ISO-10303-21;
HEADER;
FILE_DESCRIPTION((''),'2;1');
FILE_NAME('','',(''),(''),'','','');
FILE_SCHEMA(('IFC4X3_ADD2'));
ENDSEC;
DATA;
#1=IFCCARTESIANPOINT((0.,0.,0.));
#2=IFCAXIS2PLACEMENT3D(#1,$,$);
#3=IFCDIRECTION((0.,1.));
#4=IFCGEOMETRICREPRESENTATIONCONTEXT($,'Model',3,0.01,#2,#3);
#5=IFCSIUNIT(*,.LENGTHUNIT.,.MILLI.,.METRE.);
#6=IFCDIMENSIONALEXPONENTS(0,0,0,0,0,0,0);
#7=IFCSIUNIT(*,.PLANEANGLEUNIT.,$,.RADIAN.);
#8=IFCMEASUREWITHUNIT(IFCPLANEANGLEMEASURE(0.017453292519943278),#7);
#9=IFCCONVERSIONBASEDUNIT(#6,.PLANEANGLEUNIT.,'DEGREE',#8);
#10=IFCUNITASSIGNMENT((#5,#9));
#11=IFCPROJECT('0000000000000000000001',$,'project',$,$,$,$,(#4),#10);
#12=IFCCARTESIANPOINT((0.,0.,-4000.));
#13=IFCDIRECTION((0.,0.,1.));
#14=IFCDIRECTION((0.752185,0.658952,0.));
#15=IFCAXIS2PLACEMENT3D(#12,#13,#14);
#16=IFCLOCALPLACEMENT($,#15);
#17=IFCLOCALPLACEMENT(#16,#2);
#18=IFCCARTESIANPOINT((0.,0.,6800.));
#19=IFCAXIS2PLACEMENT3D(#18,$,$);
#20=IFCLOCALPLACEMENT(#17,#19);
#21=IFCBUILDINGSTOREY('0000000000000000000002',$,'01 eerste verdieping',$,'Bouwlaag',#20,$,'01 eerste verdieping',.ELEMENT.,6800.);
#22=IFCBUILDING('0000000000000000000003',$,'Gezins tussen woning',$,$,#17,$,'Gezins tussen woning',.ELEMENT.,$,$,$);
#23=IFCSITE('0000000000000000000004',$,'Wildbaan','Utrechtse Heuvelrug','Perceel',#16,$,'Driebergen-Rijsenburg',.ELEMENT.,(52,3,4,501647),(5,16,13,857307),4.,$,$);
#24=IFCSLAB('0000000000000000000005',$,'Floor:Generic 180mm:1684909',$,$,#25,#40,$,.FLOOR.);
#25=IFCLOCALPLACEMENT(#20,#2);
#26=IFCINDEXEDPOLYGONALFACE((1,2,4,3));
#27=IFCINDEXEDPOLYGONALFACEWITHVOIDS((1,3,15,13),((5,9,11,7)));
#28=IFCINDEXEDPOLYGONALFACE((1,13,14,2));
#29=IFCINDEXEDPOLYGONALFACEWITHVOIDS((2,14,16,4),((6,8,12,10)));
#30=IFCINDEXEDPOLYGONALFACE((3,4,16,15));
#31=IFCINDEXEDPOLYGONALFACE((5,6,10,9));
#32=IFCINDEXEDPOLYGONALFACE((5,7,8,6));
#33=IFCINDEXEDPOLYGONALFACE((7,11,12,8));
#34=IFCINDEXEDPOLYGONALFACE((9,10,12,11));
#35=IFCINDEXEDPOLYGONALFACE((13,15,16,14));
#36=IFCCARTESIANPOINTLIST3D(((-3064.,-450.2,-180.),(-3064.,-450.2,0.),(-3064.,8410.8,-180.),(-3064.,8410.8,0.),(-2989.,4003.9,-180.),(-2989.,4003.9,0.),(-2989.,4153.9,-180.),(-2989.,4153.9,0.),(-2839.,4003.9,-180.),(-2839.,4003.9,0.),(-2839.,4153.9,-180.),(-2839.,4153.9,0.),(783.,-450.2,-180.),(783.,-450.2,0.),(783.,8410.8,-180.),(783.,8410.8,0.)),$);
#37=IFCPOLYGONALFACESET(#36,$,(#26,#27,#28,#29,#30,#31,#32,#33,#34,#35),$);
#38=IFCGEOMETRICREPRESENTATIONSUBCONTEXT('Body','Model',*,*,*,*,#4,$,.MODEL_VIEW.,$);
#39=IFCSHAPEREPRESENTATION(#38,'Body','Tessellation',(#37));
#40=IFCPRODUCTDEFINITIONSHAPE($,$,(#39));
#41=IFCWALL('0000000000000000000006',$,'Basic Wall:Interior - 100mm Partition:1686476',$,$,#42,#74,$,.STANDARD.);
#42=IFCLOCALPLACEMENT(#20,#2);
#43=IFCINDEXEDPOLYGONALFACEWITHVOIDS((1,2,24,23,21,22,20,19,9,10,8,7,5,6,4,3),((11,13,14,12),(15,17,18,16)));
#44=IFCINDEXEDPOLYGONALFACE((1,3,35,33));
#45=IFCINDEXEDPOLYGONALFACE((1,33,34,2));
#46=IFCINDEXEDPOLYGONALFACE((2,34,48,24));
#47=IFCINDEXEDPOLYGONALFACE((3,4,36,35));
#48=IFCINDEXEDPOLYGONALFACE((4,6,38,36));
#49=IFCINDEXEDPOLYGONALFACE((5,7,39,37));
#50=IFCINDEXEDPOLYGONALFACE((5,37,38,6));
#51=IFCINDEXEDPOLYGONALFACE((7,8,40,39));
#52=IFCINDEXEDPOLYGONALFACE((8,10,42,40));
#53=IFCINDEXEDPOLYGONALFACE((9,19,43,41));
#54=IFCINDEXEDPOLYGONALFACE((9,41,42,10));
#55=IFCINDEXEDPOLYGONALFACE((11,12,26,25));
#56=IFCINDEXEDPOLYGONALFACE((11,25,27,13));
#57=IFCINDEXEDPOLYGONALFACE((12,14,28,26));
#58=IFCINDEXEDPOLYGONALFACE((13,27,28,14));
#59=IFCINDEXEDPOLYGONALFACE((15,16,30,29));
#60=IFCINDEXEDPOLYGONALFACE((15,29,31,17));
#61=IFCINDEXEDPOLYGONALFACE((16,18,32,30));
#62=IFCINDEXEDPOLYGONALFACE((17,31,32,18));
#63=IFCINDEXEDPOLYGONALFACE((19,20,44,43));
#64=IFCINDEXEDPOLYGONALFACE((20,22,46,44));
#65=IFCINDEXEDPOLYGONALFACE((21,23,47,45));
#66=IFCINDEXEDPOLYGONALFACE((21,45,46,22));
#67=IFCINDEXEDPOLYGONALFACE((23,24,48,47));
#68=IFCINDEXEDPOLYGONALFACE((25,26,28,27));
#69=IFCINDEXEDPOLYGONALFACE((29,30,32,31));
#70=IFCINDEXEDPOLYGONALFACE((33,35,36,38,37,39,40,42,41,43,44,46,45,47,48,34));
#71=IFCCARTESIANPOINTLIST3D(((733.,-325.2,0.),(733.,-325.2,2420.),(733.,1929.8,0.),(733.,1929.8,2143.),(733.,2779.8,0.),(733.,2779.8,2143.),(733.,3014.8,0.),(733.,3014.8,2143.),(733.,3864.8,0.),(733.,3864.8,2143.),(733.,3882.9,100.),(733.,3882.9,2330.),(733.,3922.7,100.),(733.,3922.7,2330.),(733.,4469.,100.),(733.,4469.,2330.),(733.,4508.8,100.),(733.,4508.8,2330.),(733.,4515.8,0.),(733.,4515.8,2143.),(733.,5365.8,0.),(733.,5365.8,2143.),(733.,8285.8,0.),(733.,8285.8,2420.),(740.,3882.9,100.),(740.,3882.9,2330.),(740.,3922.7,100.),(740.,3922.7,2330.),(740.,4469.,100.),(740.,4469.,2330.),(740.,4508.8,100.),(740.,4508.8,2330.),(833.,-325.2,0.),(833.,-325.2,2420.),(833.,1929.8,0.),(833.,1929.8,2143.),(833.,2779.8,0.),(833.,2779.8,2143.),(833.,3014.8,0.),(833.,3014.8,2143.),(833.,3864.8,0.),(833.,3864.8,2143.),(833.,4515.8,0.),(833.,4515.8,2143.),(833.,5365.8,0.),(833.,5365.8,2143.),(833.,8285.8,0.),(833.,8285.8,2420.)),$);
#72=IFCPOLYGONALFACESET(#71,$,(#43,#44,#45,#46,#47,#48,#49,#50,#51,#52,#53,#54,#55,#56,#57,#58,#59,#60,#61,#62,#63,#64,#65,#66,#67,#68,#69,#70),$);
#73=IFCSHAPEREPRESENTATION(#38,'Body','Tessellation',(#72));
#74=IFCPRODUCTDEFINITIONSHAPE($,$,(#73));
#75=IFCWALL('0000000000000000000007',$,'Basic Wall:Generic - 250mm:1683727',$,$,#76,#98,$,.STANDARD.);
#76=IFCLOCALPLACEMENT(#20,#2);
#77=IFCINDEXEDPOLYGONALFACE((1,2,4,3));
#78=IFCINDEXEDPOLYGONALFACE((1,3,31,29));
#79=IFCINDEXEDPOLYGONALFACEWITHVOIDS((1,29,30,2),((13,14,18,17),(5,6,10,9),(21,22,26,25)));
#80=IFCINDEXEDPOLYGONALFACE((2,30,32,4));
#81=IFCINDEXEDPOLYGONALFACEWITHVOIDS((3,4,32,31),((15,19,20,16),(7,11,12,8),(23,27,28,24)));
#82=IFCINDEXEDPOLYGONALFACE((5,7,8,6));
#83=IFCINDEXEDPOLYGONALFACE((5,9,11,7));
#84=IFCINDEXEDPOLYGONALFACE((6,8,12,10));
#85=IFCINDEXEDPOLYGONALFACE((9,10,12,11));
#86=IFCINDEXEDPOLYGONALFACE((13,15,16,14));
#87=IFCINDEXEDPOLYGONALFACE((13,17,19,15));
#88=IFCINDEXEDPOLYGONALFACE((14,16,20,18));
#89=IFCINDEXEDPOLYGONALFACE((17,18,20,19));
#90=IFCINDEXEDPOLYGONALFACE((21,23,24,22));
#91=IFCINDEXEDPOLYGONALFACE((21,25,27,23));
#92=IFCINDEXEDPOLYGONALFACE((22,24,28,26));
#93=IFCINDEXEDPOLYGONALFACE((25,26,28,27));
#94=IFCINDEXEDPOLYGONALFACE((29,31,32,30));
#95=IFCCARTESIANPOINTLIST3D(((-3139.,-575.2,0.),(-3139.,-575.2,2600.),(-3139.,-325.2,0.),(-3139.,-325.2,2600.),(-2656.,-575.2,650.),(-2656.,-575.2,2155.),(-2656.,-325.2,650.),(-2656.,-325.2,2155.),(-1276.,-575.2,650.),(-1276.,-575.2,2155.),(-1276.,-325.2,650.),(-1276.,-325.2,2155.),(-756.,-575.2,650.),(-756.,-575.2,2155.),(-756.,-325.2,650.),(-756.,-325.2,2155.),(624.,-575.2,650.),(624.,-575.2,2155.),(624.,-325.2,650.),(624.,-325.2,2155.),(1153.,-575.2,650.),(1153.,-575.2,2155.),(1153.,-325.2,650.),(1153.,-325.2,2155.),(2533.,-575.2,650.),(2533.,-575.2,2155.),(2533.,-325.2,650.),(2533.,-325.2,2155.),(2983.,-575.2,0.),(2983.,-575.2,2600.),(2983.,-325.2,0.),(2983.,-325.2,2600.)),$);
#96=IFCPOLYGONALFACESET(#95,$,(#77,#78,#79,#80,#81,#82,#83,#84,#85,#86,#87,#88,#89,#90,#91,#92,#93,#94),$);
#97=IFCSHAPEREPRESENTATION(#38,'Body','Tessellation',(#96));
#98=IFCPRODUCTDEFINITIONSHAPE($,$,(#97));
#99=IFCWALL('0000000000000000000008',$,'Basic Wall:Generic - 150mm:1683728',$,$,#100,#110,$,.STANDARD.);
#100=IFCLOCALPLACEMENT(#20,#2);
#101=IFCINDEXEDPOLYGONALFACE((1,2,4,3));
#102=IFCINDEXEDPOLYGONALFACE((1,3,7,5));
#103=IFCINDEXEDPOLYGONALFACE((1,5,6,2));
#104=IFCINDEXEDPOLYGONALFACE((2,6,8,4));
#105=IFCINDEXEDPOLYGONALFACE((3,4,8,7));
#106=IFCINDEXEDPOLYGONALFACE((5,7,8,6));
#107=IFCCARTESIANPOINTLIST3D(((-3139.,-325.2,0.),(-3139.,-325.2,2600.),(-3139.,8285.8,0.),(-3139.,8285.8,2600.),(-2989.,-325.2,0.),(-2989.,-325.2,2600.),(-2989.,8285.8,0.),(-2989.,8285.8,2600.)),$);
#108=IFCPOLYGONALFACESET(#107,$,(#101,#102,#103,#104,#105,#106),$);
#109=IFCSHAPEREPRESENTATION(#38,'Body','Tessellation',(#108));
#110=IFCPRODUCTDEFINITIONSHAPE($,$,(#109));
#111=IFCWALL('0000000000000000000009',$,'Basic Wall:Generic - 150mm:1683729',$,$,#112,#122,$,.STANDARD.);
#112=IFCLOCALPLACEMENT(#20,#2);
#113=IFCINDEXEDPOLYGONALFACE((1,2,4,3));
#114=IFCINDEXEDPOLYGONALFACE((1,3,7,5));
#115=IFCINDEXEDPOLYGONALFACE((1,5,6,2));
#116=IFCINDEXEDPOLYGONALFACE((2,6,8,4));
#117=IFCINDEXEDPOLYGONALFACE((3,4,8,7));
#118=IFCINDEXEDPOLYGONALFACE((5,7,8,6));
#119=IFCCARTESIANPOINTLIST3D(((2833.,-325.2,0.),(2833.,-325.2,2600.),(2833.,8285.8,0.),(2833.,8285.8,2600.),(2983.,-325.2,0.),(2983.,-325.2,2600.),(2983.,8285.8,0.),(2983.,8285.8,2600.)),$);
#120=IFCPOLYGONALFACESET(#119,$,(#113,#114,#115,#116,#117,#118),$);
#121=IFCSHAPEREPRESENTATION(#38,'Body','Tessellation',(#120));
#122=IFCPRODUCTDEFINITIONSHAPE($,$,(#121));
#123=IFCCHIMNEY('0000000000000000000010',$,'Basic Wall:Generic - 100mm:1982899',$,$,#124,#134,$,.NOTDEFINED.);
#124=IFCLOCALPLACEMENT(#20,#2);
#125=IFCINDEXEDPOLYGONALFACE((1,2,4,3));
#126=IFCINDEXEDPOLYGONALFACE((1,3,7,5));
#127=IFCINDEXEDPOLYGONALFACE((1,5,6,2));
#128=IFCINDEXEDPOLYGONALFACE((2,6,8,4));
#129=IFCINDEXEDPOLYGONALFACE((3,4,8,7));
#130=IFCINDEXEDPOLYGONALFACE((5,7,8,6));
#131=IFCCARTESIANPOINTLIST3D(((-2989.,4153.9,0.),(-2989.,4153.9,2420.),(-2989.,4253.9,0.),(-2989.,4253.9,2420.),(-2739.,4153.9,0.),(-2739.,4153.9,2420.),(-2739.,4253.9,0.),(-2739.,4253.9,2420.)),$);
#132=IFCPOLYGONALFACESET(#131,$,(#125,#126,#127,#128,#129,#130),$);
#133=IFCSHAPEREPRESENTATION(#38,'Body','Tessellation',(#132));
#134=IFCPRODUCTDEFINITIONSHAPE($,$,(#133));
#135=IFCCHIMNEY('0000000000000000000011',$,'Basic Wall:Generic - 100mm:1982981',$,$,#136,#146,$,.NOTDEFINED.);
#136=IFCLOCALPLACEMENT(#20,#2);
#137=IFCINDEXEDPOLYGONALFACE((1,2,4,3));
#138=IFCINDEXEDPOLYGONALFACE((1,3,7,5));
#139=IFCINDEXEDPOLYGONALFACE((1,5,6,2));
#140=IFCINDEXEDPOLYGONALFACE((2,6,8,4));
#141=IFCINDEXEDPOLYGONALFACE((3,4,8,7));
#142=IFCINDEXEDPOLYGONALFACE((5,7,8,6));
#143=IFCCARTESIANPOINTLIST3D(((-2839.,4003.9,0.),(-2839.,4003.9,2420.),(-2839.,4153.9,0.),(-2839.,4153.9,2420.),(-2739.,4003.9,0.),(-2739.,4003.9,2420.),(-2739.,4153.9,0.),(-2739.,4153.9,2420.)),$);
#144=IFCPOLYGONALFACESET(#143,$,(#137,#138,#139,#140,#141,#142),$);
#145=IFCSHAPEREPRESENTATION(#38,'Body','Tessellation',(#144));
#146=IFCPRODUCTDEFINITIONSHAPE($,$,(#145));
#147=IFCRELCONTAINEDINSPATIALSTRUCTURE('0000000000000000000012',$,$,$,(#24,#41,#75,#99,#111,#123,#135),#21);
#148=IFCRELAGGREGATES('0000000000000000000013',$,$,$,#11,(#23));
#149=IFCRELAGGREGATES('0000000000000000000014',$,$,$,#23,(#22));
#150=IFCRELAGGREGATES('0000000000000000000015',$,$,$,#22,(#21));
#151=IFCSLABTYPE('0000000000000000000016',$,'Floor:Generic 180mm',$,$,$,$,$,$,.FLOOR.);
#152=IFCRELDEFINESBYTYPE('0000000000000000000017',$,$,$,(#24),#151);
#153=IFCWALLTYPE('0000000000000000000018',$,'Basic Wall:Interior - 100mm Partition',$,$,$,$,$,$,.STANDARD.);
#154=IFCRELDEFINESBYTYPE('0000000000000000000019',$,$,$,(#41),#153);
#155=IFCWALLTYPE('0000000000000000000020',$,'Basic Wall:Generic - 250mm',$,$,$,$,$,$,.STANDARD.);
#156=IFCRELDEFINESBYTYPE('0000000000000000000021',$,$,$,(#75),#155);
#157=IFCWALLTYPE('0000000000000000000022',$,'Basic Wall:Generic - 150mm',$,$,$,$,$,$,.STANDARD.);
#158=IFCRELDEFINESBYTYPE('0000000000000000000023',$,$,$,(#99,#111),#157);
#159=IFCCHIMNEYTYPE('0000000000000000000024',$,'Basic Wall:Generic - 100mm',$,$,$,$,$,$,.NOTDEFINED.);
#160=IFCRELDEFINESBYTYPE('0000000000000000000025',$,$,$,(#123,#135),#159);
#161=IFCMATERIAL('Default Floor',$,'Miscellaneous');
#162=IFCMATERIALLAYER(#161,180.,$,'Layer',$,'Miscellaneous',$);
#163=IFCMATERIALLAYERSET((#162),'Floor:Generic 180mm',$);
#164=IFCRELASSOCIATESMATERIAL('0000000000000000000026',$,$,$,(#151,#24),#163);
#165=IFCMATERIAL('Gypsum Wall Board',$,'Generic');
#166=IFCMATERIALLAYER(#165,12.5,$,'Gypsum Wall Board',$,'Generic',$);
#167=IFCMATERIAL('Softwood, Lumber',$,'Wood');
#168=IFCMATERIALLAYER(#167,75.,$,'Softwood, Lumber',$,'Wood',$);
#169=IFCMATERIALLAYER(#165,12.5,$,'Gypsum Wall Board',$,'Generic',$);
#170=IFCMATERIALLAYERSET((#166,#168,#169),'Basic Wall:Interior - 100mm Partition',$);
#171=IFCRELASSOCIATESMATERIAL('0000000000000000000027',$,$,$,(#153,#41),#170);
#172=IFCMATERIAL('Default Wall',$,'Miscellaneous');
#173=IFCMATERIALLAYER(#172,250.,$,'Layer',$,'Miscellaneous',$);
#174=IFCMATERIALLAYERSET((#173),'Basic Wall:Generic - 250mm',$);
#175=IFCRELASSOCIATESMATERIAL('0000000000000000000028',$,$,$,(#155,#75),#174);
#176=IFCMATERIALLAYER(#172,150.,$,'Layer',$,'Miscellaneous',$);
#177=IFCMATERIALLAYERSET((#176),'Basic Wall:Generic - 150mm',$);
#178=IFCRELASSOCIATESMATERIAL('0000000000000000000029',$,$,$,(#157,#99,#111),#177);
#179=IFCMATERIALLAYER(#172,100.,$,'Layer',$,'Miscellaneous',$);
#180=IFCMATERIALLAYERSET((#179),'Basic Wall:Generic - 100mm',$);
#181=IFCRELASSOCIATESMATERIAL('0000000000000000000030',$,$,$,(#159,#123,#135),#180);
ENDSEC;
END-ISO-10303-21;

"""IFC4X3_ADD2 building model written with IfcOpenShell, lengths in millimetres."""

from ifc_helpers import new_model, entity, si_unit, converted_unit, direction, frame, frame_2d, origin, place, context, subcontext, project, spatial, rectangle, extrude, boolean, material, layer, layer_set, layer_usage, type_object, element, save


model = new_model("IFC4X3_ADD2")

# Units and contexts
model_context = context("Model", 3, precision=0.01, world=origin(), true_north=direction((0.0, 1.0)))
body_context = subcontext(model_context, "Body", "Model", "MODEL_VIEW")
ifc_project = project(units=[si_unit("LENGTHUNIT", "METRE", prefix="MILLI"), converted_unit("PLANEANGLEUNIT", "DEGREE", entity("IfcPlaneAngleMeasure", 0.017453292519943278), si_unit("PLANEANGLEUNIT", "RADIAN"), dimensions=[0, 0, 0, 0, 0, 0, 0])], contexts=[model_context])

# Site, building, storey
site_placement = place(None, frame((0.0, 0.0, -4000.0), z_axis=(0.0, 0.0, 1.0), x_axis=(0.752185, 0.658952, 0.0)))
site = spatial("IfcSite", under=ifc_project, at=site_placement, Name="Wildbaan", Description="Utrechtse Heuvelrug", ObjectType="Perceel", LongName="Driebergen-Rijsenburg", CompositionType="ELEMENT", RefLatitude=(52, 3, 4, 501647), RefLongitude=(5, 16, 13, 857307), RefElevation=4.0)
building_placement = place(site_placement, origin())
building = spatial("IfcBuilding", under=site, at=building_placement, Name="Gezins tussen woning", LongName="Gezins tussen woning", CompositionType="ELEMENT")
storey_placement = place(building_placement, frame((0.0, 0.0, 6800.0)))
storey = spatial("IfcBuildingStorey", under=building, at=storey_placement, Name="01 eerste verdieping", ObjectType="Bouwlaag", LongName="01 eerste verdieping", CompositionType="ELEMENT", Elevation=6800.0)

# Slab, opening
ifc_material_1 = material(Name="Default Floor", Category="Miscellaneous")
ifc_layer_1 = layer(ifc_material_1, 180.0, Name="Layer", Category="Miscellaneous")
ifc_layer_set_1 = layer_set([ifc_layer_1], Name="Floor:Generic 180mm")
ifc_layer_usage_1 = layer_usage(ifc_layer_set_1, "AXIS3", "POSITIVE", 0.0)
slab_type = type_object("IfcSlabType", Name="Floor:Generic 180mm", PredefinedType="FLOOR", material=ifc_layer_set_1)
slab_1_placement = place(storey_placement, origin())
slab_1 = element("IfcSlab", 1, at=slab_1_placement, inside=storey, type_object=slab_type, material=ifc_layer_usage_1, Name="Floor:Generic 180mm:1684909", PredefinedType="FLOOR", context=body_context, shape_type="CSG", body=[
    boolean("DIFFERENCE", extrude(rectangle(XDim=8861.0, YDim=3847.0, at=frame_2d((0.0, 0.0), x_axis=(1.0, 0.0))), frame((-1140.5, 3980.3, 0.0), z_axis=(0.0, 0.0, -1.0), x_axis=(0.0, 1.0, 0.0)), (0.0, 0.0, 1.0), 180.0), extrude(rectangle(XDim=150.0, YDim=150.0, at=frame_2d((0.0, 0.0), x_axis=(1.0, 0.0))), frame((-2914.0, 4078.9, -180.0), z_axis=(0.0, 0.0, 1.0), x_axis=(0.0, 1.0, 0.0)), (0.0, 0.0, 1.0), 180.0)),
])
opening_1_placement = place(slab_1_placement, origin())
element("IfcOpeningElement", 2, at=opening_1_placement, cuts=slab_1, PredefinedType="OPENING", context=body_context, shape_type="SweptSolid", body=[
    extrude(rectangle(XDim=150.0, YDim=150.0, at=frame_2d((-2914.0, 4078.9), x_axis=(0.0, -1.0))), origin(), (0.0, 0.0, -1.0), 180.0),
])

# Walls, openings
ifc_material_2 = material(Name="Gypsum Wall Board", Category="Generic")
ifc_layer_2 = layer(ifc_material_2, 12.5, Name="Gypsum Wall Board", Category="Generic")
ifc_material_3 = material(Name="Softwood, Lumber", Category="Wood")
ifc_layer_3 = layer(ifc_material_3, 75.0, Name="Softwood, Lumber", Category="Wood")
ifc_layer_4 = layer(ifc_material_2, 12.5, Name="Gypsum Wall Board", Category="Generic")
ifc_layer_set_2 = layer_set([ifc_layer_2, ifc_layer_3, ifc_layer_4], Name="Basic Wall:Interior - 100mm Partition")
wall_type_1 = type_object("IfcWallType", Name="Basic Wall:Interior - 100mm Partition", PredefinedType="STANDARD", material=ifc_layer_set_2)
wall_1_placement = place(storey_placement, frame((783.0, -325.2, 0.0), z_axis=(0.0, 0.0, 1.0), x_axis=(0.0, 1.0, 0.0)))
wall_1 = element("IfcWall", 3, at=wall_1_placement, inside=storey, type_object=wall_type_1, material=ifc_layer_set_2, Name="Basic Wall:Interior - 100mm Partition:1686476", PredefinedType="STANDARD", context=body_context, shape_type="SweptSolid", body=[
    extrude(rectangle(XDim=8611.0, YDim=100.0, at=frame_2d((4305.5, 0.0), x_axis=(1.0, 0.0))), origin(), (0.0, 0.0, 1.0), 2420.0),
])
opening_2_placement = place(wall_1_placement, frame((325.2, 783.0, 100.0)))
element("IfcOpeningElement", 4, at=opening_2_placement, cuts=wall_1, PredefinedType="OPENING", context=body_context, shape_type="SweptSolid", body=[
    extrude(rectangle(XDim=2230.0, YDim=39.8, at=frame_2d((0.0, 0.0), x_axis=(0.0, 1.0))), frame((4488.9, -740.0, 1115.0), z_axis=(0.0, 1.0, 0.0), x_axis=(1.0, 0.0, 0.0)), (0.0, 0.0, 1.0), 810.0),
])
opening_3_placement = place(wall_1_placement, frame((325.2, 783.0, 100.0)))
element("IfcOpeningElement", 5, at=opening_3_placement, cuts=wall_1, PredefinedType="OPENING", context=body_context, shape_type="SweptSolid", body=[
    extrude(rectangle(XDim=2230.0, YDim=39.8, at=frame_2d((0.0, 0.0), x_axis=(0.0, 1.0))), frame((3902.8, -740.0, 1115.0), z_axis=(0.0, 1.0, 0.0), x_axis=(1.0, 0.0, 0.0)), (0.0, 0.0, 1.0), 810.0),
])
opening_4_placement = place(wall_1_placement, frame((325.2, 783.0, -2.0), z_axis=(0.0, 0.0, 1.0), x_axis=(0.0, -1.0, 0.0)))
element("IfcOpeningElement", 6, at=opening_4_placement, cuts=wall_1, PredefinedType="OPENING", context=body_context, shape_type="SweptSolid", body=[
    extrude(rectangle(XDim=2145.0, YDim=850.0, at=frame_2d((0.0, 0.0), x_axis=(1.0, 0.0))), frame((833.0, 3439.8, 1072.5), z_axis=(-1.0, 0.0, 0.0), x_axis=(0.0, 0.0, -1.0)), (0.0, 0.0, 1.0), 100.0),
])
opening_5_placement = place(wall_1_placement, frame((325.2, 783.0, -2.0), z_axis=(0.0, 0.0, 1.0), x_axis=(0.0, -1.0, 0.0)))
element("IfcOpeningElement", 7, at=opening_5_placement, cuts=wall_1, PredefinedType="OPENING", context=body_context, shape_type="SweptSolid", body=[
    extrude(rectangle(XDim=2145.0, YDim=850.0, at=frame_2d((0.0, 0.0), x_axis=(0.0, 1.0))), frame((833.0, 4940.8, 1072.5), z_axis=(-1.0, 0.0, 0.0), x_axis=(0.0, 1.0, 0.0)), (0.0, 0.0, 1.0), 100.0),
])
opening_6_placement = place(wall_1_placement, frame((325.2, 783.0, -2.0), z_axis=(0.0, 0.0, 1.0), x_axis=(0.0, -1.0, 0.0)))
element("IfcOpeningElement", 8, at=opening_6_placement, cuts=wall_1, PredefinedType="OPENING", context=body_context, shape_type="SweptSolid", body=[
    extrude(rectangle(XDim=2145.0, YDim=850.0, at=frame_2d((0.0, 0.0), x_axis=(1.0, 0.0))), frame((833.0, 2354.8, 1072.5), z_axis=(-1.0, 0.0, 0.0), x_axis=(0.0, 0.0, -1.0)), (0.0, 0.0, 1.0), 100.0),
])
ifc_material_4 = material(Name="Default Wall", Category="Miscellaneous")
ifc_layer_5 = layer(ifc_material_4, 250.0, Name="Layer", Category="Miscellaneous")
ifc_layer_set_3 = layer_set([ifc_layer_5], Name="Basic Wall:Generic - 250mm")
wall_type_2 = type_object("IfcWallType", Name="Basic Wall:Generic - 250mm", PredefinedType="STANDARD", material=ifc_layer_set_3)
wall_2_placement = place(storey_placement, frame((-3139.0, -450.2, 0.0)))
wall_2 = element("IfcWall", 9, at=wall_2_placement, inside=storey, type_object=wall_type_2, material=ifc_layer_set_3, Name="Basic Wall:Generic - 250mm:1683727", PredefinedType="STANDARD", context=body_context, shape_type="SweptSolid", body=[
    extrude(rectangle(XDim=6122.0, YDim=250.0, at=frame_2d((3061.0, 0.0), x_axis=(-1.0, 0.0))), origin(), (0.0, 0.0, 1.0), 2600.0),
])
opening_7_placement = place(wall_2_placement, frame((3139.0, 450.2, 650.0)))
element("IfcOpeningElement", 10, at=opening_7_placement, cuts=wall_2, PredefinedType="OPENING", context=body_context, shape_type="SweptSolid", body=[
    extrude(rectangle(XDim=1505.0, YDim=1380.0, at=frame_2d((0.0, 0.0), x_axis=(0.0, 1.0))), frame((-1966.0, -575.2, 752.5), z_axis=(0.0, 1.0, 0.0), x_axis=(1.0, 0.0, 0.0)), (0.0, 0.0, 1.0), 250.0),
])
opening_8_placement = place(wall_2_placement, frame((3139.0, 450.2, 650.0)))
element("IfcOpeningElement", 11, at=opening_8_placement, cuts=wall_2, PredefinedType="OPENING", context=body_context, shape_type="SweptSolid", body=[
    extrude(rectangle(XDim=1505.0, YDim=1380.0, at=frame_2d((0.0, 0.0), x_axis=(0.0, 1.0))), frame((-66.0, -575.2, 752.5), z_axis=(0.0, 1.0, 0.0), x_axis=(1.0, 0.0, 0.0)), (0.0, 0.0, 1.0), 250.0),
])
opening_9_placement = place(wall_2_placement, frame((3139.0, 450.2, 650.0)))
element("IfcOpeningElement", 12, at=opening_9_placement, cuts=wall_2, PredefinedType="OPENING", context=body_context, shape_type="SweptSolid", body=[
    extrude(rectangle(XDim=1505.0, YDim=1380.0, at=frame_2d((0.0, 0.0), x_axis=(0.0, 1.0))), frame((1843.0, -575.2, 752.5), z_axis=(0.0, 1.0, 0.0), x_axis=(1.0, 0.0, 0.0)), (0.0, 0.0, 1.0), 250.0),
])

# Walls
ifc_layer_6 = layer(ifc_material_4, 150.0, Name="Layer", Category="Miscellaneous")
ifc_layer_set_4 = layer_set([ifc_layer_6], Name="Basic Wall:Generic - 150mm")
wall_type_3 = type_object("IfcWallType", Name="Basic Wall:Generic - 150mm", PredefinedType="STANDARD", material=ifc_layer_set_4)
wall_3_placement = place(storey_placement, frame((-3064.0, -325.2, 0.0), z_axis=(0.0, 0.0, 1.0), x_axis=(0.0, 1.0, 0.0)))
element("IfcWall", 13, at=wall_3_placement, inside=storey, type_object=wall_type_3, material=ifc_layer_set_4, Name="Basic Wall:Generic - 150mm:1683728", PredefinedType="STANDARD", context=body_context, shape_type="SweptSolid", body=[
    extrude(rectangle(XDim=8611.0, YDim=150.0, at=frame_2d((4305.5, 0.0), x_axis=(-1.0, 0.0))), origin(), (0.0, 0.0, 1.0), 2600.0),
])
wall_4_placement = place(storey_placement, frame((2908.0, -325.2, 0.0), z_axis=(0.0, 0.0, 1.0), x_axis=(0.0, 1.0, 0.0)))
element("IfcWall", 14, at=wall_4_placement, inside=storey, type_object=wall_type_3, material=ifc_layer_set_4, Name="Basic Wall:Generic - 150mm:1683729", PredefinedType="STANDARD", context=body_context, shape_type="SweptSolid", body=[
    extrude(rectangle(XDim=8611.0, YDim=150.0, at=frame_2d((4305.5, 0.0), x_axis=(-1.0, 0.0))), origin(), (0.0, 0.0, 1.0), 2600.0),
])

# Chimneys
ifc_layer_7 = layer(ifc_material_4, 100.0, Name="Layer", Category="Miscellaneous")
ifc_layer_set_5 = layer_set([ifc_layer_7], Name="Basic Wall:Generic - 100mm")
ifc_layer_usage_2 = layer_usage(ifc_layer_set_5, "AXIS2", "NEGATIVE", 50.0)
chimney_type = type_object("IfcChimneyType", Name="Basic Wall:Generic - 100mm", PredefinedType="NOTDEFINED", material=ifc_layer_set_5)
chimney_1_placement = place(storey_placement, frame((-2989.0, 4203.9, 0.0)))
element("IfcChimney", 15, at=chimney_1_placement, inside=storey, type_object=chimney_type, material=ifc_layer_usage_2, Name="Basic Wall:Generic - 100mm:1982899", PredefinedType="NOTDEFINED", context=body_context, shape_type="SweptSolid", body=[
    extrude(rectangle(XDim=250.0, YDim=100.0, at=frame_2d((125.0, 0.0), x_axis=(-1.0, 0.0))), origin(), (0.0, 0.0, 1.0), 2420.0),
])
ifc_layer_usage_3 = layer_usage(ifc_layer_set_5, "AXIS2", "NEGATIVE", 50.0)
chimney_2_placement = place(storey_placement, frame((-2789.0, 4153.9, 0.0), z_axis=(0.0, 0.0, 1.0), x_axis=(0.0, -1.0, 0.0)))
element("IfcChimney", 16, at=chimney_2_placement, inside=storey, type_object=chimney_type, material=ifc_layer_usage_3, Name="Basic Wall:Generic - 100mm:1982981", PredefinedType="NOTDEFINED", context=body_context, shape_type="SweptSolid", body=[
    extrude(rectangle(XDim=150.0, YDim=100.0, at=frame_2d((75.0, 0.0), x_axis=(-1.0, 0.0))), origin(), (0.0, 0.0, 1.0), 2420.0),
])

save(model, "model.ifc")
